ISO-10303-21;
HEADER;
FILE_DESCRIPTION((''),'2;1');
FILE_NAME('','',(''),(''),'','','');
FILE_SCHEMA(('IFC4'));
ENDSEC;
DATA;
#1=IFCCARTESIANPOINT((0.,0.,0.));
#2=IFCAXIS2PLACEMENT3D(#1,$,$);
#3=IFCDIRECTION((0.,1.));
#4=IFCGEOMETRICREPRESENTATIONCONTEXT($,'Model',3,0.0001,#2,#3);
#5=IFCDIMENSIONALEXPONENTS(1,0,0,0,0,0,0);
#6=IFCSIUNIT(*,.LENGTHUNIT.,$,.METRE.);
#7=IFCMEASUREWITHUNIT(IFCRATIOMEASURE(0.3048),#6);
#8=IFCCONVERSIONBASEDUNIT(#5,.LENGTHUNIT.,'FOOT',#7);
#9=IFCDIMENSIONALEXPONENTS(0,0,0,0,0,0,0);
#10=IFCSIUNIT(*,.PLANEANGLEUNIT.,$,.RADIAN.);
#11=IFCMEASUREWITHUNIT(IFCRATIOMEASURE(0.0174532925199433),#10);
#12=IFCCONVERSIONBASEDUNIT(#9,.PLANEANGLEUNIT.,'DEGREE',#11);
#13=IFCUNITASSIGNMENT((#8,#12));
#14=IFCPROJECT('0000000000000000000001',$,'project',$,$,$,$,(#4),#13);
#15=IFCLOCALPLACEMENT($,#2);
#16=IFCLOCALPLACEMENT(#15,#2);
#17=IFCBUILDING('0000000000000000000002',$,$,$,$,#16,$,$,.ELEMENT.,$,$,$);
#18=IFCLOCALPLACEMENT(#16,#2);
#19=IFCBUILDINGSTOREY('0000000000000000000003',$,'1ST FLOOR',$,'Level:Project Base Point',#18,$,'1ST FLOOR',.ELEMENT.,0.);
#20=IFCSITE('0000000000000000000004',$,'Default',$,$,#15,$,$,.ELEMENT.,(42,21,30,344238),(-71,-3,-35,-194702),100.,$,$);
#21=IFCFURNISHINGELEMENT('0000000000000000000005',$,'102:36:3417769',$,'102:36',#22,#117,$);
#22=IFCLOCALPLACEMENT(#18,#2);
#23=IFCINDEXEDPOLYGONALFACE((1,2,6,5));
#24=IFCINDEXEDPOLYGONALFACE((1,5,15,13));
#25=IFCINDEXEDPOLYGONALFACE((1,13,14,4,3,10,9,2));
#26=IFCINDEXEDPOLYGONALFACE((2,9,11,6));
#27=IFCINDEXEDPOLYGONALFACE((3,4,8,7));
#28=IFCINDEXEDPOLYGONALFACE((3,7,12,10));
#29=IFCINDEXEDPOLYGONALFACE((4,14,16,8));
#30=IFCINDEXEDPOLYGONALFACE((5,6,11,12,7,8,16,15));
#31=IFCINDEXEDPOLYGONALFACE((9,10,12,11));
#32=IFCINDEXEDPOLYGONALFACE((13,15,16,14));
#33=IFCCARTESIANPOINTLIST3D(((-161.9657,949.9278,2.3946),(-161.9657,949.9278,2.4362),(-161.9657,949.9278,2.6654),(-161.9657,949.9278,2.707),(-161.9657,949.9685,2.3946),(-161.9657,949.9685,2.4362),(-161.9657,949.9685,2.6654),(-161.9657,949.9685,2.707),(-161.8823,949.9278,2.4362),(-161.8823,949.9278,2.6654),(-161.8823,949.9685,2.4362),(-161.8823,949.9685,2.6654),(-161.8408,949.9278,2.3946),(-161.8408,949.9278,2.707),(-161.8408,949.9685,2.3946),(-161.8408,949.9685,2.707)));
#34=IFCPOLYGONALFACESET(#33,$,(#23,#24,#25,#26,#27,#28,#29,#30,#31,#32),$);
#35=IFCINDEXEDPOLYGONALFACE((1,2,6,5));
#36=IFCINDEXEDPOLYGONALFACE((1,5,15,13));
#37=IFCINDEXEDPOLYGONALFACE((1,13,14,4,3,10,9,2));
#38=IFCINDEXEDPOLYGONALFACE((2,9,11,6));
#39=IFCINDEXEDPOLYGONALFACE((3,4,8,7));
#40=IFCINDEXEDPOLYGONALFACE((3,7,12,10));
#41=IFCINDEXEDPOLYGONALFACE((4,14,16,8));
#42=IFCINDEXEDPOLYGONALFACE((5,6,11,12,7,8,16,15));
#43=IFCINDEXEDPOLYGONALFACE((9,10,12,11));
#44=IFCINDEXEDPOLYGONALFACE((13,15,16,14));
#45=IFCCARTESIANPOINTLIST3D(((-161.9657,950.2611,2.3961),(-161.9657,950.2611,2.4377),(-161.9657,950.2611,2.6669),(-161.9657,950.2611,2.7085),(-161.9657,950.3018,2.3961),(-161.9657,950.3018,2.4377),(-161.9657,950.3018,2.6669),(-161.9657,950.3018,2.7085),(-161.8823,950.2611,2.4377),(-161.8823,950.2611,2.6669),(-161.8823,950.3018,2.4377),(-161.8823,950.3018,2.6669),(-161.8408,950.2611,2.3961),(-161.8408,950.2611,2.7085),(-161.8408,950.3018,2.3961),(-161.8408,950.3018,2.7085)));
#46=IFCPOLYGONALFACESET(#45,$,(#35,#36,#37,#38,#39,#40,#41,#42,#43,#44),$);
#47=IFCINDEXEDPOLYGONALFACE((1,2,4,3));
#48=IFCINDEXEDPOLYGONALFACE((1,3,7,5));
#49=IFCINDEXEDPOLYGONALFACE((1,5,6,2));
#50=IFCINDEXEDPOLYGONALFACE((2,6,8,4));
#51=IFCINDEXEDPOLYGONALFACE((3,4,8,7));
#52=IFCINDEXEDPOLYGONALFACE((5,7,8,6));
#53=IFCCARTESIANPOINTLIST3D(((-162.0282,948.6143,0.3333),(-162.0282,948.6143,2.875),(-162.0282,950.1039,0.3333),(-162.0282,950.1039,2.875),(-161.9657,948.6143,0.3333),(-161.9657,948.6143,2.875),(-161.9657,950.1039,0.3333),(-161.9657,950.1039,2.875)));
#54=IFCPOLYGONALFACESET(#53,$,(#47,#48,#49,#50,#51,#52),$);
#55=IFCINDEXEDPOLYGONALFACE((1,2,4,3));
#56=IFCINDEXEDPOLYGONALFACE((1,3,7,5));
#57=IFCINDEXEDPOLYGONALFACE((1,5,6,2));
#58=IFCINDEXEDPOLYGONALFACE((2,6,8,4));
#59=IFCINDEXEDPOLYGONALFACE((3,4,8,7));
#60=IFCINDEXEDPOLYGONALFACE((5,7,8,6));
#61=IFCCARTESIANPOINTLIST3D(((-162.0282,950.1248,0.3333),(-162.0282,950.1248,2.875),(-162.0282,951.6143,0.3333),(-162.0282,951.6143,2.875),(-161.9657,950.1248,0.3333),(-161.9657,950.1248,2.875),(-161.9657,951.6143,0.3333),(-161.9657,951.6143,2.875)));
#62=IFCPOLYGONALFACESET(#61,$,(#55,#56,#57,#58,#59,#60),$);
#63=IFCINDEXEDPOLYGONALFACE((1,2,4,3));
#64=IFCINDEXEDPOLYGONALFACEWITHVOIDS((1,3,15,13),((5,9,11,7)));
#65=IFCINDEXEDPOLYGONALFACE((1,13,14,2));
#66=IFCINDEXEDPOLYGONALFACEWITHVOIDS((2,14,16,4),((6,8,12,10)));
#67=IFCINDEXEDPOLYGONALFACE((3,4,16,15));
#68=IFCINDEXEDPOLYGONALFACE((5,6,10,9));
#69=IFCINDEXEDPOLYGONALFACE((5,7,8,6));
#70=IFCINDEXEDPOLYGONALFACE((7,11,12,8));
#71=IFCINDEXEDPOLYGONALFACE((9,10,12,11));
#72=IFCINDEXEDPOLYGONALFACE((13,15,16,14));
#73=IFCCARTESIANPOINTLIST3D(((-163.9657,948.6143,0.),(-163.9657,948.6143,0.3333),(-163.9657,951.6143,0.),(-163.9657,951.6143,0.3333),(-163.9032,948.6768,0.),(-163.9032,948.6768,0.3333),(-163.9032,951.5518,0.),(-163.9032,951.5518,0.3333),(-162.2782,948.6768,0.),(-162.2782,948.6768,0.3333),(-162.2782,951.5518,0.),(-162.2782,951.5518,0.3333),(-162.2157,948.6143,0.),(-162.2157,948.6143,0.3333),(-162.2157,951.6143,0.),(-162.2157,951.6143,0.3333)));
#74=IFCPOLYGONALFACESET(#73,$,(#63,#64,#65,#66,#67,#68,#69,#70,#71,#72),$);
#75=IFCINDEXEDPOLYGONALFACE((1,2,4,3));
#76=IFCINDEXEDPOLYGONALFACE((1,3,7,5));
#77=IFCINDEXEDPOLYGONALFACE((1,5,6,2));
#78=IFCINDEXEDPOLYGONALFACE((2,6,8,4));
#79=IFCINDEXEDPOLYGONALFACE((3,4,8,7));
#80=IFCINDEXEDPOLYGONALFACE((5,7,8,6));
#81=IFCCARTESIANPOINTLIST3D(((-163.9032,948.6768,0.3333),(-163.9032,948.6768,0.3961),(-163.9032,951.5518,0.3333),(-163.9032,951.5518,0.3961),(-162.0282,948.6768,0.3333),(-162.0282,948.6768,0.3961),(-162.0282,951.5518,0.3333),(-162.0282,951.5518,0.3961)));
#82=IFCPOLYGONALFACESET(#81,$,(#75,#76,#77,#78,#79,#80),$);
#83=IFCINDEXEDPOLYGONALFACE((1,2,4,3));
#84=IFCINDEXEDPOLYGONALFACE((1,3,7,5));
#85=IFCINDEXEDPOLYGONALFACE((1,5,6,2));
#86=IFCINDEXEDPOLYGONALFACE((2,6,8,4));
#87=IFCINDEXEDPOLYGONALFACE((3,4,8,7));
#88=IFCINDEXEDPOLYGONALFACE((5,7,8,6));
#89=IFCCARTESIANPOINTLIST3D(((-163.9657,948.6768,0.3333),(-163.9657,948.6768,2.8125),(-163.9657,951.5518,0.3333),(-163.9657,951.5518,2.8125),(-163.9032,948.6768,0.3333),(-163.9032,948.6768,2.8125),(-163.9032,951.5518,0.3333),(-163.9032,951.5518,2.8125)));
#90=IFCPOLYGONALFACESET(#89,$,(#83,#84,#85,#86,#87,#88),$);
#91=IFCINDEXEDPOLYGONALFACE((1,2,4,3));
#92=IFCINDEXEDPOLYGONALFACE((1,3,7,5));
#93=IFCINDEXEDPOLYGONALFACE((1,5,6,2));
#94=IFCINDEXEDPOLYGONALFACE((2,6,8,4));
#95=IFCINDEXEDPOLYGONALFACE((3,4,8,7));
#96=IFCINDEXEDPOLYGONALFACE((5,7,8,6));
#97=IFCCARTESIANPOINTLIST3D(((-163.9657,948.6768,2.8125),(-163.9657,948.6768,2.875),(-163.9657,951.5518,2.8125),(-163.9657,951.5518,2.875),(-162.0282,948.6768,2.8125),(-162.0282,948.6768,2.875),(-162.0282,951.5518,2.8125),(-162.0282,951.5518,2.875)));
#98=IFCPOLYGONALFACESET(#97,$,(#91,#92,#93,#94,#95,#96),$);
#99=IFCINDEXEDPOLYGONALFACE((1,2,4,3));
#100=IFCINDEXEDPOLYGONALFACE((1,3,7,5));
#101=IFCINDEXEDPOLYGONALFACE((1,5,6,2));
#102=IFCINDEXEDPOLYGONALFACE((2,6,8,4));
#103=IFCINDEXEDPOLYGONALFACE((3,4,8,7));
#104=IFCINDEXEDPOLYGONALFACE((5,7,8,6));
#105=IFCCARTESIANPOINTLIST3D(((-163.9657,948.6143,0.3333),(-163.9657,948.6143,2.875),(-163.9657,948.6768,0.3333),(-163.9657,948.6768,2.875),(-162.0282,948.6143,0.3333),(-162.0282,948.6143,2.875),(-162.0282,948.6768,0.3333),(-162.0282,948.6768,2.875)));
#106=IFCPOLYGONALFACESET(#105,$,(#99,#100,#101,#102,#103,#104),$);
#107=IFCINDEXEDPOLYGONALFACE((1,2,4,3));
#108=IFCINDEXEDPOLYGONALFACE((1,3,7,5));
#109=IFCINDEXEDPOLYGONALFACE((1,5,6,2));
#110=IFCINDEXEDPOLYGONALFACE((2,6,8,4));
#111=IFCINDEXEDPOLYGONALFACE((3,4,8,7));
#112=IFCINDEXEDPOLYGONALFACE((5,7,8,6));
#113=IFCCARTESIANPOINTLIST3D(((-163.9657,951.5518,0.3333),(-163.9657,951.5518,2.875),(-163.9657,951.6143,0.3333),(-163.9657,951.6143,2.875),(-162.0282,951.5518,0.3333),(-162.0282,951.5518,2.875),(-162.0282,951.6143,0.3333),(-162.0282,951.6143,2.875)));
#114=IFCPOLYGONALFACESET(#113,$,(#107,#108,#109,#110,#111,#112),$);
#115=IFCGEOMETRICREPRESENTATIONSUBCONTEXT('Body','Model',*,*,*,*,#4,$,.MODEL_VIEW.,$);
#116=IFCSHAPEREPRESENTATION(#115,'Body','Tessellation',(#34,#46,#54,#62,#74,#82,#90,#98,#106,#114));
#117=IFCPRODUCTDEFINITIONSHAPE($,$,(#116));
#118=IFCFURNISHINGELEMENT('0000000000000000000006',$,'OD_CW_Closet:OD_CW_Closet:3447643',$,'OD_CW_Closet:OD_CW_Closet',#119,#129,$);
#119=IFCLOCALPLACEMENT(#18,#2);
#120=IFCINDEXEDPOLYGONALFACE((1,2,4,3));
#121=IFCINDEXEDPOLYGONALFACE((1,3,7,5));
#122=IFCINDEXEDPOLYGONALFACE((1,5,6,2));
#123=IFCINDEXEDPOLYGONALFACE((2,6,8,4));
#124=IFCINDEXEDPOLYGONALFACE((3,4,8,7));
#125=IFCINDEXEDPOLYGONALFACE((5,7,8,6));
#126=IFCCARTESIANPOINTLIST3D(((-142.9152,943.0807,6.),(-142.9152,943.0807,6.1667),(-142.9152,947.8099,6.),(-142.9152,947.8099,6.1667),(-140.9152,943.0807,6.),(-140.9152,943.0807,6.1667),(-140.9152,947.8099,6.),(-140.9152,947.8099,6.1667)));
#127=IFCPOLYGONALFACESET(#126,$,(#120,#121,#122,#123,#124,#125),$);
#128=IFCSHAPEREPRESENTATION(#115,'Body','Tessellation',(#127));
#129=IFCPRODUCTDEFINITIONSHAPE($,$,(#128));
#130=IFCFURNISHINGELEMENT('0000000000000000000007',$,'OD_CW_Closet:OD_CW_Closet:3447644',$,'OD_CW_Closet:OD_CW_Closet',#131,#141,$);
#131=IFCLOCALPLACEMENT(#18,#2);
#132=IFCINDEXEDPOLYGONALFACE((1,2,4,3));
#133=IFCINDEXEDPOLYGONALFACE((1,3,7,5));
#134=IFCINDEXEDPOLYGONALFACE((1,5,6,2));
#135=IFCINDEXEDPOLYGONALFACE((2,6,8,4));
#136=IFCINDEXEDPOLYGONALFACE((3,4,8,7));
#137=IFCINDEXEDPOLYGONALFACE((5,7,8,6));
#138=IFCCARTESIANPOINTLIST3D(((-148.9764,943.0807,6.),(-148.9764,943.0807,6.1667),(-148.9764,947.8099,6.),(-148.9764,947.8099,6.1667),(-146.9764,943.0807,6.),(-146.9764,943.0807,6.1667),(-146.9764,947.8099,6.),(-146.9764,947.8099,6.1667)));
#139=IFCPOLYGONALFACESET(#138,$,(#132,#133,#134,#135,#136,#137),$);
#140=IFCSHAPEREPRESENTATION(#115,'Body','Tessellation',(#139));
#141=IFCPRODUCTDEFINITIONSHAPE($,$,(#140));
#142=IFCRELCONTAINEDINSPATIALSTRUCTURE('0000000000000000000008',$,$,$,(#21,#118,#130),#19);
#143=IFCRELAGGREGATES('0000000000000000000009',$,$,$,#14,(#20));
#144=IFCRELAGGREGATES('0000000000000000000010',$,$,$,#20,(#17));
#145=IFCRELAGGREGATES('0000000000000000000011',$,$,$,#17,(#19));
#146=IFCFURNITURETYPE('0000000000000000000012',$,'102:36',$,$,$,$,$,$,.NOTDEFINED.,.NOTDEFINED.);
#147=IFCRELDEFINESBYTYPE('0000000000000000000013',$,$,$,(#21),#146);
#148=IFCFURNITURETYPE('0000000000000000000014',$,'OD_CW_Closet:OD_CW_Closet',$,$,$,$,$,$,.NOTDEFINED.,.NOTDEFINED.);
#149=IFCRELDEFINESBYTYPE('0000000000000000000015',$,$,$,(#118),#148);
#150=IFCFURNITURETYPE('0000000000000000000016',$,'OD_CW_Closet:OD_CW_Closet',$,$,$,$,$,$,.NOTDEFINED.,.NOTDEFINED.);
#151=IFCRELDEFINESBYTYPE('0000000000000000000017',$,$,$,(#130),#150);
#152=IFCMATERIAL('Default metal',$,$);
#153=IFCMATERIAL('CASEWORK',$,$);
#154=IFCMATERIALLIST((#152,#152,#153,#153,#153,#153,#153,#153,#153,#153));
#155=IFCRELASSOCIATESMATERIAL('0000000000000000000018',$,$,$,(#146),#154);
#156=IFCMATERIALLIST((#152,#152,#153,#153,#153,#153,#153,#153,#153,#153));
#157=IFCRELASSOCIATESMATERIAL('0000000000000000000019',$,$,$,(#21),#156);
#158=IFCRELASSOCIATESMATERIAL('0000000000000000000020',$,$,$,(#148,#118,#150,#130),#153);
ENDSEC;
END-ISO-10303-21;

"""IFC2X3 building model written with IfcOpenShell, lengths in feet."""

from ifc_helpers import new_model, entity, si_unit, converted_unit, direction, frame, frame_2d, origin, origin_2d_with_axis, place, context, subcontext, project, spatial, polyline, rectangle, outline, extrude, source, transform, mapped, material, material_list, type_object, type_shapes, element, save


model = new_model("IFC2X3")

# Units and contexts
model_context = context("Model", 3, precision=0.0001, world=origin(), true_north=direction((0.0, 1.0)))
body_context = subcontext(model_context, "Body", "Model", "MODEL_VIEW")
ifc_project = project(units=[converted_unit("LENGTHUNIT", "FOOT", entity("IfcRatioMeasure", 0.3048), si_unit("LENGTHUNIT", "METRE"), dimensions=[1, 0, 0, 0, 0, 0, 0]), converted_unit("PLANEANGLEUNIT", "DEGREE", entity("IfcRatioMeasure", 0.0174532925199433), si_unit("PLANEANGLEUNIT", "RADIAN"), dimensions=[0, 0, 0, 0, 0, 0, 0])], contexts=[model_context])

# Site, building, storey
site_placement = place(None, origin())
site = spatial("IfcSite", under=ifc_project, at=site_placement, Name="Default", CompositionType="ELEMENT", RefLatitude=(42, 21, 30, 344238), RefLongitude=(-71, -3, -35, -194702), RefElevation=100.0)
building_placement = place(site_placement, origin())
building = spatial("IfcBuilding", under=site, at=building_placement, CompositionType="ELEMENT")
storey_placement = place(building_placement, origin())
storey = spatial("IfcBuildingStorey", under=building, at=storey_placement, Name="1ST FLOOR", ObjectType="Level:Project Base Point", LongName="1ST FLOOR", CompositionType="ELEMENT", Elevation=0.0)

# Shared definitions
ifc_material_1 = material(Name="CASEWORK")

# Furnishing elements
ifc_material_2 = material(Name="Default metal")
ifc_material_list_1 = material_list([ifc_material_2, ifc_material_2, ifc_material_1, ifc_material_1, ifc_material_1, ifc_material_1, ifc_material_1, ifc_material_1, ifc_material_1, ifc_material_1])
ifc_material_list_2 = material_list([ifc_material_2, ifc_material_2, ifc_material_1, ifc_material_1, ifc_material_1, ifc_material_1, ifc_material_1, ifc_material_1, ifc_material_1, ifc_material_1])
furniture_type_1 = type_object("IfcFurnitureType", Name="102:36", material=ifc_material_list_2)
shared_shape_1 = source(origin(), body_context, "Body", "SweptSolid", [
    extrude(outline(polyline([(-0.0521, -0.1146), (-0.0521, -0.1562), (0.0729, -0.1562), (0.0729, 0.1562), (-0.0521, 0.1562), (-0.0521, 0.1146), (0.0313, 0.1146), (0.0313, -0.1146), (-0.0521, -0.1146)])), frame((0.2073, 2.0521, 2.5508), z_axis=(-1.0, 0.0, 0.0), x_axis=(0.0, 1.0, 0.0)), (0.0, 0.0, -1.0), 0.0407),
    extrude(outline(polyline([(-0.0521, -0.1146), (-0.0521, -0.1562), (0.0729, -0.1562), (0.0729, 0.1562), (-0.0521, 0.1562), (-0.0521, 0.1146), (0.0313, 0.1146), (0.0313, -0.1146), (-0.0521, -0.1146)])), frame((-0.126, 2.0521, 2.5523), z_axis=(-1.0, 0.0, 0.0), x_axis=(0.0, 1.0, 0.0)), (0.0, 0.0, -1.0), 0.0407),
    extrude(rectangle(XDim=1.4896, YDim=0.0625, at=frame_2d((0.0, 0.0), x_axis=(1.0, 0.0))), frame((0.8167, 1.9688, 0.3333), z_axis=(0.0, 0.0, 1.0), x_axis=(-1.0, 0.0, 0.0)), (0.0, 0.0, 1.0), 2.5417),
    extrude(rectangle(XDim=1.4896, YDim=0.0625, at=origin_2d_with_axis()), frame((-0.6937, 1.9688, 0.3333), z_axis=(0.0, 0.0, 1.0), x_axis=(-1.0, 0.0, 0.0)), (0.0, 0.0, 1.0), 2.5417),
    extrude(outline(polyline([(-0.875, -1.5), (0.875, -1.5), (0.875, 1.5), (-0.875, 1.5), (-0.875, -1.5)]), holes=[polyline([(-0.8125, -1.4375), (-0.8125, 1.4375), (0.8125, 1.4375), (0.8125, -1.4375), (-0.8125, -1.4375)])]), frame((0.0615, 0.875, 0.0), z_axis=(0.0, 0.0, 1.0), x_axis=(0.0, -1.0, 0.0)), (0.0, 0.0, 1.0), 0.3333),
    extrude(rectangle(XDim=1.875, YDim=2.875, at=origin_2d_with_axis()), frame((0.0615, 1.0, 0.3333), z_axis=(0.0, 0.0, 1.0), x_axis=(0.0, 1.0, 0.0)), (0.0, 0.0, 1.0), 0.0627),
    extrude(rectangle(XDim=2.875, YDim=0.0625, at=origin_2d_with_axis()), frame((0.0615, 0.0312, 0.3333), z_axis=(0.0, 0.0, 1.0), x_axis=(-1.0, 0.0, 0.0)), (0.0, 0.0, 1.0), 2.4792),
    extrude(rectangle(XDim=1.9375, YDim=2.875, at=frame_2d((0.0, 0.0), x_axis=(1.0, 0.0))), frame((0.0615, 0.9688, 2.8125), z_axis=(0.0, 0.0, 1.0), x_axis=(0.0, 1.0, 0.0)), (0.0, 0.0, 1.0), 0.0625),
    extrude(rectangle(XDim=1.9375, YDim=0.0625, at=frame_2d((0.0, 0.0), x_axis=(1.0, 0.0))), frame((1.5302, 0.9687, 0.3333), z_axis=(0.0, 0.0, 1.0), x_axis=(0.0, -1.0, 0.0)), (0.0, 0.0, 1.0), 2.5417),
    extrude(rectangle(XDim=1.9375, YDim=0.0625, at=frame_2d((0.0, 0.0), x_axis=(1.0, 0.0))), frame((-1.4073, 0.9687, 0.3333), z_axis=(0.0, 0.0, 1.0), x_axis=(0.0, -1.0, 0.0)), (0.0, 0.0, 1.0), 2.5417),
])
type_shapes(furniture_type_1, [shared_shape_1])
furnishing_1_placement = place(storey_placement, frame((-163.9657, 950.1758, 0.0), z_axis=(0.0, 0.0, 1.0), x_axis=(0.0, -1.0, 0.0)))
element("IfcFurnishingElement", 1, at=furnishing_1_placement, inside=storey, type_object=furniture_type_1, material=ifc_material_list_1, Name="102:36:3417769", ObjectType="102:36", context=body_context, shape_type="MappedRepresentation", body=[
    mapped(shared_shape_1, transform((0.0, 0.0, 0.0), scale=1.0)),
])
furniture_type_2 = type_object("IfcFurnitureType", Name="OD_CW_Closet:OD_CW_Closet", material=ifc_material_1)
shared_shape_2 = source(origin(), body_context, "Body", "SweptSolid", [
    extrude(rectangle(XDim=2.0, YDim=4.7292, at=origin_2d_with_axis()), frame((2.3646, 1.0, 0.0), z_axis=(0.0, 0.0, 1.0), x_axis=(0.0, -1.0, 0.0)), (0.0, 0.0, 1.0), 0.1667),
])
type_shapes(furniture_type_2, [shared_shape_2])
furnishing_2_placement = place(storey_placement, frame((-142.9152, 947.8099, 6.0), z_axis=(0.0, 0.0, 1.0), x_axis=(0.0, -1.0, 0.0)))
element("IfcFurnishingElement", 2, at=furnishing_2_placement, inside=storey, type_object=furniture_type_2, material=ifc_material_1, Name="OD_CW_Closet:OD_CW_Closet:3447643", ObjectType="OD_CW_Closet:OD_CW_Closet", context=body_context, shape_type="MappedRepresentation", body=[
    mapped(shared_shape_2, transform((0.0, 0.0, 0.0), scale=1.0)),
])
furniture_type_3 = type_object("IfcFurnitureType", Name="OD_CW_Closet:OD_CW_Closet", material=ifc_material_1)
shared_shape_3 = source(origin(), body_context, "Body", "SweptSolid", [
    extrude(rectangle(XDim=4.7292, YDim=2.0, at=origin_2d_with_axis()), frame((2.3646, 1.0, 0.0)), (0.0, 0.0, 1.0), 0.1667),
])
type_shapes(furniture_type_3, [shared_shape_3])
furnishing_3_placement = place(storey_placement, frame((-148.9764, 947.8099, 6.0), z_axis=(0.0, 0.0, 1.0), x_axis=(0.0, -1.0, 0.0)))
element("IfcFurnishingElement", 3, at=furnishing_3_placement, inside=storey, type_object=furniture_type_3, material=ifc_material_1, Name="OD_CW_Closet:OD_CW_Closet:3447644", ObjectType="OD_CW_Closet:OD_CW_Closet", context=body_context, shape_type="MappedRepresentation", body=[
    mapped(shared_shape_3, transform((0.0, 0.0, 0.0), scale=1.0)),
])

save(model, "model.ifc")
